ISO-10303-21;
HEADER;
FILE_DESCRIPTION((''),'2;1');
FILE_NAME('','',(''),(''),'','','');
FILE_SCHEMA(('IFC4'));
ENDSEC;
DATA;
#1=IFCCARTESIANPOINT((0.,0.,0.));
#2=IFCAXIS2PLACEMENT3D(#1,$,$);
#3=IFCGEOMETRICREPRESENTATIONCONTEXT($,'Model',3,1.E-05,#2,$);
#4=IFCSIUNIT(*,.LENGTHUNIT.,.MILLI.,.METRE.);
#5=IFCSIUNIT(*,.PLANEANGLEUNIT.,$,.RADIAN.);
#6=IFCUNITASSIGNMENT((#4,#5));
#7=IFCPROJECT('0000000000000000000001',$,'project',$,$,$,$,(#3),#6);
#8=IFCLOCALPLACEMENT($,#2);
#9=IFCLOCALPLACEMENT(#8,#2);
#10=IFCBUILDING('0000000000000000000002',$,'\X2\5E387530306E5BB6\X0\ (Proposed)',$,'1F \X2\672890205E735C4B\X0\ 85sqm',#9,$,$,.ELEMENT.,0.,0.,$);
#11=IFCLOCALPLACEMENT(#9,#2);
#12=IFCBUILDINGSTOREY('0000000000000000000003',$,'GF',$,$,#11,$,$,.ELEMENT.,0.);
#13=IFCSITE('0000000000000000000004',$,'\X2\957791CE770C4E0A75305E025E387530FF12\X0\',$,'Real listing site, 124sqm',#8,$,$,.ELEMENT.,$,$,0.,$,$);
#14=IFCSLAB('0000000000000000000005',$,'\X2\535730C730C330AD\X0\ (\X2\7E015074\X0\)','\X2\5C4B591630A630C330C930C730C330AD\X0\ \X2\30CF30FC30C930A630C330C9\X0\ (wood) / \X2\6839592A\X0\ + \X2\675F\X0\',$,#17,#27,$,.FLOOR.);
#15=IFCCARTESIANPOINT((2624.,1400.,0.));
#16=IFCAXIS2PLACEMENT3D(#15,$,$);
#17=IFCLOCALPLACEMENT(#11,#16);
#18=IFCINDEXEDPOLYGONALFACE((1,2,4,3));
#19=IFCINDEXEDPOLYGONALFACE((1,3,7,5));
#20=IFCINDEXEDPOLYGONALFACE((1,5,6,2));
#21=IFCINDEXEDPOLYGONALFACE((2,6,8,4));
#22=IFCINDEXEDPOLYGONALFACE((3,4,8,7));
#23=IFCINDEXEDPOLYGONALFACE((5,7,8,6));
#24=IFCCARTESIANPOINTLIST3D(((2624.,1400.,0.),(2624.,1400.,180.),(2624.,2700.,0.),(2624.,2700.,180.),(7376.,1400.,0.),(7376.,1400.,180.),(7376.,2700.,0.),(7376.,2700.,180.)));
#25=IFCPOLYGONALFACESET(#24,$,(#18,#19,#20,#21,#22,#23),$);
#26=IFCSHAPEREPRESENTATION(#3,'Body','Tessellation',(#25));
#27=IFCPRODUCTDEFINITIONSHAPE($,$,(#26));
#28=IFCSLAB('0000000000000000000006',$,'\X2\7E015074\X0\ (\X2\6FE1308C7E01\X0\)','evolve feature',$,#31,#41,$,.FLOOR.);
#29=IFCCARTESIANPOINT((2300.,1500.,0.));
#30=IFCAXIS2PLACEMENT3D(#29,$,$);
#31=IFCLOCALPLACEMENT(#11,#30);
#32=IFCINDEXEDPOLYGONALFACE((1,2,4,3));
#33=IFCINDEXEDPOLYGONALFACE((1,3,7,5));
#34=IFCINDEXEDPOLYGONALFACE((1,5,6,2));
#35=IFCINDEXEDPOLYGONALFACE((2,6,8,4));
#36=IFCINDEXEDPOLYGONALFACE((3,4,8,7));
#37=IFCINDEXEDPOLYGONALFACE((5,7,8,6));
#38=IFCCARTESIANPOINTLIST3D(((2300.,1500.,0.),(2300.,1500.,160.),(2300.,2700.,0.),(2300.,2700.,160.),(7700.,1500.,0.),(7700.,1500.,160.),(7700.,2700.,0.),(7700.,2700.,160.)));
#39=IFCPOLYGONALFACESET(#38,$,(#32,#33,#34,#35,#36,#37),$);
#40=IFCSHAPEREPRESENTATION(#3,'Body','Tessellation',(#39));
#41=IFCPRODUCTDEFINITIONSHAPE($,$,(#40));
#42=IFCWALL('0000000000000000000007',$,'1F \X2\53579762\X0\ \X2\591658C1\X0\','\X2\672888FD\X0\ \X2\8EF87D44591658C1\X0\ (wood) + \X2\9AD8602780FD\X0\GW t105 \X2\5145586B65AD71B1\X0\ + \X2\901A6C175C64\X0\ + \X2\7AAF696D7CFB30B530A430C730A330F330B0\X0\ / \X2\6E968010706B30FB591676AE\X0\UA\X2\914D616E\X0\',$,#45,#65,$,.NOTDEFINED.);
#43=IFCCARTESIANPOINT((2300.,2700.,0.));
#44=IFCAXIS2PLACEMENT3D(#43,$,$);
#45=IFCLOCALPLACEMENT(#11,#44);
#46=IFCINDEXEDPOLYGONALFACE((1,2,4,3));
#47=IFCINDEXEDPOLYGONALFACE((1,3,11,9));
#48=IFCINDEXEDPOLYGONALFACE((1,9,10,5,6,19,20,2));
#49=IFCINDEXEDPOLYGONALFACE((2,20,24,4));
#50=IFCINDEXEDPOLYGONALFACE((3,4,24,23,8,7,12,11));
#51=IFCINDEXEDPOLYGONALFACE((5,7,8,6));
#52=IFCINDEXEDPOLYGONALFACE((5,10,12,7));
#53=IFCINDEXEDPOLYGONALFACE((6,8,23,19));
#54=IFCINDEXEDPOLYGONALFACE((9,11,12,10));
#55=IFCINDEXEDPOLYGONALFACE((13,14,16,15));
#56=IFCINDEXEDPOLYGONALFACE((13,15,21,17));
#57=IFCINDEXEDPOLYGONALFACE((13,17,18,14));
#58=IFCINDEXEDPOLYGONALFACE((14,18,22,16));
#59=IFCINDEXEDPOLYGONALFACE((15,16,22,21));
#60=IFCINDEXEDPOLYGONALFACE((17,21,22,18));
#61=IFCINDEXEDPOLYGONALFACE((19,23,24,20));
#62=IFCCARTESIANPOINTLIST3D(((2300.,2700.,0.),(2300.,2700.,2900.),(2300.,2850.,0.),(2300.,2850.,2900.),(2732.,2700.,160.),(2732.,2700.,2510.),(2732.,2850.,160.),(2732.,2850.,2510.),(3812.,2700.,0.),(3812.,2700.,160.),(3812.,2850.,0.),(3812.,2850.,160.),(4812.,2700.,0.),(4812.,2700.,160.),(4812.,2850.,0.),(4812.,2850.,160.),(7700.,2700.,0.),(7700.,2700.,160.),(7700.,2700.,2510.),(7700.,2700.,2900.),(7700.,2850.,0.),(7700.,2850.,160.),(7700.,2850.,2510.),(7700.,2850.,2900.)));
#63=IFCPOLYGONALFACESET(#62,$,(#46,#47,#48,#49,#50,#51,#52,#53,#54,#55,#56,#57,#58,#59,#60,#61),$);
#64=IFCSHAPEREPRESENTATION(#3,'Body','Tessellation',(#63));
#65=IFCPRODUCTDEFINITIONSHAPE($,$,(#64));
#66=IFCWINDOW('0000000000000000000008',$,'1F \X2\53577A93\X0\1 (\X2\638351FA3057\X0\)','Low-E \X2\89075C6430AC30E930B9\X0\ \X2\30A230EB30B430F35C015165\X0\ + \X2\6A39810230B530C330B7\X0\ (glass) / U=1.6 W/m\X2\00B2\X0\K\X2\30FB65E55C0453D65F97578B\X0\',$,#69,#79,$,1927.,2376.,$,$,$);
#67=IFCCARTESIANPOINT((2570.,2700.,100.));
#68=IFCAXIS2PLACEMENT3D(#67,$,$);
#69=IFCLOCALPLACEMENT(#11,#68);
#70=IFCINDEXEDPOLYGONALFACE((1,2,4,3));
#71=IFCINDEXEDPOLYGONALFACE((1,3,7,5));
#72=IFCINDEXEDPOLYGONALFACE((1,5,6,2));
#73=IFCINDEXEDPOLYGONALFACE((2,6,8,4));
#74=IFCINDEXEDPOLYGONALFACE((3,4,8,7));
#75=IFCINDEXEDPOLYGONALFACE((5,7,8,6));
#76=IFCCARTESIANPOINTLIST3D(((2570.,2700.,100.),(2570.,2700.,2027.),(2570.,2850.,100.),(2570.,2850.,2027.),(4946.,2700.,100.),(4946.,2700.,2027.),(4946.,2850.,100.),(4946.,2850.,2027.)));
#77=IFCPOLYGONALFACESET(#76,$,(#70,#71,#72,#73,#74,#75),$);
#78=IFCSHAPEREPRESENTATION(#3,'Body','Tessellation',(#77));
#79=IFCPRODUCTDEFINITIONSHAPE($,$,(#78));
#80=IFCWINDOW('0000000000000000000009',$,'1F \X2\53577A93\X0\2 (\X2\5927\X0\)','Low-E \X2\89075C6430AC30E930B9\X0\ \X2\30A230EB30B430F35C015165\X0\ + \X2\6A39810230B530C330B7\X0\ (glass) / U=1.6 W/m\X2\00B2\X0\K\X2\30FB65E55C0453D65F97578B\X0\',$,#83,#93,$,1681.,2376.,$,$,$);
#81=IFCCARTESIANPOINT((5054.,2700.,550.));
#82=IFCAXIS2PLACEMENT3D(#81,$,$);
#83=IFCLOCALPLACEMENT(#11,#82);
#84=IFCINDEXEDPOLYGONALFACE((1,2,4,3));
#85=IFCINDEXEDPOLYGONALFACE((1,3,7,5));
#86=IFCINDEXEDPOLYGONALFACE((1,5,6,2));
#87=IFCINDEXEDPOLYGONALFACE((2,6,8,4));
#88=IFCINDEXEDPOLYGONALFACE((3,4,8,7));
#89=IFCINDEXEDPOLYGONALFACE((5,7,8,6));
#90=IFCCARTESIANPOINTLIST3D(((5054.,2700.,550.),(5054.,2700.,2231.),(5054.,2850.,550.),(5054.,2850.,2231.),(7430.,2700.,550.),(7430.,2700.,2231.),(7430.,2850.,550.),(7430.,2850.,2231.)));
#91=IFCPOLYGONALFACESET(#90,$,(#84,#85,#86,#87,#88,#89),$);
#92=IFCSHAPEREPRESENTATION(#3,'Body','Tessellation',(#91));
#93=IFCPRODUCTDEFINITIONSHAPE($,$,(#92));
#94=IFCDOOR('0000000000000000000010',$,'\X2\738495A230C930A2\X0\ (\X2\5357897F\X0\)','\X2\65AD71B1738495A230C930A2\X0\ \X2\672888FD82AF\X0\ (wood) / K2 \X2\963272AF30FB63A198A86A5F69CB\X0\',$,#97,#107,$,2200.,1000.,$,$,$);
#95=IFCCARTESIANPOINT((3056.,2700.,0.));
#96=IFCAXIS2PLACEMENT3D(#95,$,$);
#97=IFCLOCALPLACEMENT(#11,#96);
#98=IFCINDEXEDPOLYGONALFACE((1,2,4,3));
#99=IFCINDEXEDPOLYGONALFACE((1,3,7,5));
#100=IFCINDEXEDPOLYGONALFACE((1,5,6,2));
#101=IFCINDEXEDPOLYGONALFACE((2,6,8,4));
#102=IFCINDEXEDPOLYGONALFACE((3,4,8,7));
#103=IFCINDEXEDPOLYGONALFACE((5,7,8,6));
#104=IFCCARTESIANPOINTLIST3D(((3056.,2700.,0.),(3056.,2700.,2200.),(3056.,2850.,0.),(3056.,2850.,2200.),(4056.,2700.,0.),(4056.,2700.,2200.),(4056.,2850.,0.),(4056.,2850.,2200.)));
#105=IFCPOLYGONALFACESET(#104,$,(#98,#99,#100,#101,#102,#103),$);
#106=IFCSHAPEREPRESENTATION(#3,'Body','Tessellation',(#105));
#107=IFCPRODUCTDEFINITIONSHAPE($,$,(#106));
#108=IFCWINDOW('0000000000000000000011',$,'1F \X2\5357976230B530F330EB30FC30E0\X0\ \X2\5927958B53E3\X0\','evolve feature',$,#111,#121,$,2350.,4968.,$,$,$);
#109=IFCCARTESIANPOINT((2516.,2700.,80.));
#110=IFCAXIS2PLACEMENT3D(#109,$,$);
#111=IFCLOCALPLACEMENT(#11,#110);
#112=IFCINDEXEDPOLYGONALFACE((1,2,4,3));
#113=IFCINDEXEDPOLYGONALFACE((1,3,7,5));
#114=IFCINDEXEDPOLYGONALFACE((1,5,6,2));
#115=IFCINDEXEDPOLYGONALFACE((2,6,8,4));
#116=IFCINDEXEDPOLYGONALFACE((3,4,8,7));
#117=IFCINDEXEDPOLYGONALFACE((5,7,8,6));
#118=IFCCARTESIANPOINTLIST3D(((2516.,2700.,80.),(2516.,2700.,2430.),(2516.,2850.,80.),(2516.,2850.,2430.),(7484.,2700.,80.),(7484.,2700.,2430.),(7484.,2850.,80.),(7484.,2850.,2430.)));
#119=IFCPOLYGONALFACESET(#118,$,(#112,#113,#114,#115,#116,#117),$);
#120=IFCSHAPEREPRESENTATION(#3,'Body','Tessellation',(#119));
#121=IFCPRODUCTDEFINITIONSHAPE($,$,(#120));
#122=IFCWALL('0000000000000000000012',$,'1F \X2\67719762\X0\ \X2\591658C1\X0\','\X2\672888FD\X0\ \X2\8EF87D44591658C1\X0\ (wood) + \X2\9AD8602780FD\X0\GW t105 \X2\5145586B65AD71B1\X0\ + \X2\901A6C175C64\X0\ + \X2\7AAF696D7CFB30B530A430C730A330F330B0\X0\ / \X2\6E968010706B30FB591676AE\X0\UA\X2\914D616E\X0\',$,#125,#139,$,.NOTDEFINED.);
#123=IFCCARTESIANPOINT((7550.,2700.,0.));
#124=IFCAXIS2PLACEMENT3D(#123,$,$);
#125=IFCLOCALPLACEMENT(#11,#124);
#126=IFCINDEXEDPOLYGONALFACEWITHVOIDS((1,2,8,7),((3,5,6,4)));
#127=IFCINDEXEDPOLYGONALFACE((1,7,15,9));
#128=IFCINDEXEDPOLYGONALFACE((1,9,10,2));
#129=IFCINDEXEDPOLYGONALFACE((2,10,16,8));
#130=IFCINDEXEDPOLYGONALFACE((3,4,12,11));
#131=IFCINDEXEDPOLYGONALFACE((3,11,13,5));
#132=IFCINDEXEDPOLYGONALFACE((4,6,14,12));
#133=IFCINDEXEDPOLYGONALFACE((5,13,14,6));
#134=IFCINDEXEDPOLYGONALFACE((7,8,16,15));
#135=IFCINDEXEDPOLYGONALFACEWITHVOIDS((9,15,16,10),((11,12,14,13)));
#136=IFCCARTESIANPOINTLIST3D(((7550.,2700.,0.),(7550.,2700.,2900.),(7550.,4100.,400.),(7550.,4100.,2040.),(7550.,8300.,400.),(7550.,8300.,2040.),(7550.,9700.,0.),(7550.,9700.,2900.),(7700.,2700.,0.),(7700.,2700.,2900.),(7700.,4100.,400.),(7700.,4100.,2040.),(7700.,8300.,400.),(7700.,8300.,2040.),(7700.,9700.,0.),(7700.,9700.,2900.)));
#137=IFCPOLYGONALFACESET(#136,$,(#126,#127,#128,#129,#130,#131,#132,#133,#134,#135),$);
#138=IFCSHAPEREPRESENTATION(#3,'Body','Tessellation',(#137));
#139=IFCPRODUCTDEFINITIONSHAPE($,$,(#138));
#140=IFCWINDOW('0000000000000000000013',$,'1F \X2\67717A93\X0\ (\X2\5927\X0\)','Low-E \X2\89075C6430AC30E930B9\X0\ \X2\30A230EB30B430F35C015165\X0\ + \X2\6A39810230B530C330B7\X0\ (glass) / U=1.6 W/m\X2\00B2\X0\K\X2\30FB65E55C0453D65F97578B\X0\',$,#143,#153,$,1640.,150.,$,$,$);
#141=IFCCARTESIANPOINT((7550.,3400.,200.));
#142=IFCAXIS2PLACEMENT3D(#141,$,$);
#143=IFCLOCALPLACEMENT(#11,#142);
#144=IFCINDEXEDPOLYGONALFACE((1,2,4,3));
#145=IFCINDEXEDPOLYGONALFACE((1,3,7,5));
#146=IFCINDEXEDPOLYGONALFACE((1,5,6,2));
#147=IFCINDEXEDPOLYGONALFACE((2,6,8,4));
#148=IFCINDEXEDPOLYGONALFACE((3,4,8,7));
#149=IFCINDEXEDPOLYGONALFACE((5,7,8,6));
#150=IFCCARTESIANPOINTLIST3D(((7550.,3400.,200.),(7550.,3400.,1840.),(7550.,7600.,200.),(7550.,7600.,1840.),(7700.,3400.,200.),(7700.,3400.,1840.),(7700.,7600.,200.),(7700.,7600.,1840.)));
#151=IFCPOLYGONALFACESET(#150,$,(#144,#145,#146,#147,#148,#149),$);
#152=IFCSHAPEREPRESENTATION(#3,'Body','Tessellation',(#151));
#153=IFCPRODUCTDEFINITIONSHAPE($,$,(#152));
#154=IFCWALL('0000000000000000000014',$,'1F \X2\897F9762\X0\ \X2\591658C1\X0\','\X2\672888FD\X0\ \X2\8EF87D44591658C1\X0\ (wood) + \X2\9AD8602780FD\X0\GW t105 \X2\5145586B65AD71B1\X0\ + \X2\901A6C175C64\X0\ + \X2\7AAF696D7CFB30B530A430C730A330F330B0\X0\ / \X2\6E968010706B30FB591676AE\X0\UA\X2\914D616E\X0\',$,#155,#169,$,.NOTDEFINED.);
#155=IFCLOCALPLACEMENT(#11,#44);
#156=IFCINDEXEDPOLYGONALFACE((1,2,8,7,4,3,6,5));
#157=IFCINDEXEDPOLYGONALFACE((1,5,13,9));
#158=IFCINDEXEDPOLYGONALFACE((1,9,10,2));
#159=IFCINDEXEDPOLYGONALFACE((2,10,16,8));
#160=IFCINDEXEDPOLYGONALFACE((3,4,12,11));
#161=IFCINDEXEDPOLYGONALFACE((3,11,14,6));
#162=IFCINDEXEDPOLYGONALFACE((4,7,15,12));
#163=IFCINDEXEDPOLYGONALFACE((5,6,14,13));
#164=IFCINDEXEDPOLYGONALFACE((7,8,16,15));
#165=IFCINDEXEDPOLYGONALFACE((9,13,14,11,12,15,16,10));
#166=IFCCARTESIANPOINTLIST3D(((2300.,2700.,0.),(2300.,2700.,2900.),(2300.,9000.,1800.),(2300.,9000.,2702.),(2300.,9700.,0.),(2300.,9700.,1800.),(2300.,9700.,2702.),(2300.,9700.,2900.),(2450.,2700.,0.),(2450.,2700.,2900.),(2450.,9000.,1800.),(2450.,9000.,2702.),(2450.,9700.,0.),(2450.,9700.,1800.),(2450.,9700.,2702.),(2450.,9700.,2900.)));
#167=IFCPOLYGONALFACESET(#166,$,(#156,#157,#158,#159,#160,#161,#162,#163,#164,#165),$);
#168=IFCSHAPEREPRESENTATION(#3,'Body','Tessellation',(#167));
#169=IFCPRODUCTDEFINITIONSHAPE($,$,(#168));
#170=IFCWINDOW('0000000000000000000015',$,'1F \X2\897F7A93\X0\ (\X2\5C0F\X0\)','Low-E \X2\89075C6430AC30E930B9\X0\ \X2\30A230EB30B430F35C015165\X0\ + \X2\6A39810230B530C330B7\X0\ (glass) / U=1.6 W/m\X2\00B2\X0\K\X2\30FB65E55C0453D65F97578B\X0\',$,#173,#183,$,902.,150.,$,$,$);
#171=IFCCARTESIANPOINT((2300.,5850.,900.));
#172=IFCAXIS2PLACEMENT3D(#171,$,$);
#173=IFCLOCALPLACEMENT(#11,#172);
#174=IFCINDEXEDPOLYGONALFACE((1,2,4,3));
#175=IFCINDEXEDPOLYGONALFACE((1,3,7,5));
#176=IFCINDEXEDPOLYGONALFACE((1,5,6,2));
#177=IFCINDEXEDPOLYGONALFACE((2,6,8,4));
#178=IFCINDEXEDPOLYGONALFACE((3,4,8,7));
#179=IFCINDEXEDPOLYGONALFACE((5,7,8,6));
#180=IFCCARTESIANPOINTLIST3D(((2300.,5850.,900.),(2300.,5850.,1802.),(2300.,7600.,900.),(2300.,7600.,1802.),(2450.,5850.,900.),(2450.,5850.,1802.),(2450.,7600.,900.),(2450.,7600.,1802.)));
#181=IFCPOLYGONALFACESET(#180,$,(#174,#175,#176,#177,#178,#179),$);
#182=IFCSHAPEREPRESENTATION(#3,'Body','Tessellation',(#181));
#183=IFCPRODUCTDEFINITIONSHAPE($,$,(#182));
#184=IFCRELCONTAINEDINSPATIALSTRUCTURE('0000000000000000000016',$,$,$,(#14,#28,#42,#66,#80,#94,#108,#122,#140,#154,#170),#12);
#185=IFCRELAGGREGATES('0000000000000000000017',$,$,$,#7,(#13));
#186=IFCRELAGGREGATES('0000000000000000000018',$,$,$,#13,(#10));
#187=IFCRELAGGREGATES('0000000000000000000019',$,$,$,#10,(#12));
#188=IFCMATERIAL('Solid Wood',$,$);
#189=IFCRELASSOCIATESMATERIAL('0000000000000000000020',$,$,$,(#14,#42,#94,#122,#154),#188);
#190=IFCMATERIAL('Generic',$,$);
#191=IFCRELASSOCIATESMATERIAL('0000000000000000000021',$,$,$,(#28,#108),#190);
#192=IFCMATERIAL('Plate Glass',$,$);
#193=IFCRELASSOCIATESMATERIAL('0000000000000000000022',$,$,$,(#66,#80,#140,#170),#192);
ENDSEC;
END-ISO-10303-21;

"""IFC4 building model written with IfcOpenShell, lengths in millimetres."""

from ifc_helpers import new_model, si_unit, frame, frame_2d, origin, place, context, project, spatial, rectangle, extrude, material, element, fill, save


model = new_model("IFC4")

# Units and contexts
model_context = context("Model", 3, precision=1e-05, world=origin())
ifc_project = project(units=[si_unit("LENGTHUNIT", "METRE", prefix="MILLI"), si_unit("PLANEANGLEUNIT", "RADIAN")], contexts=[model_context])

# Site, building, storey
site_placement = place(None, origin())
site = spatial("IfcSite", under=ifc_project, at=site_placement, Name="長野県上田市常田２", ObjectType="Real listing site, 124sqm", CompositionType="ELEMENT", RefElevation=0.0)
building_placement = place(site_placement, origin())
building = spatial("IfcBuilding", under=site, at=building_placement, Name="常田の家 (Proposed)", ObjectType="1F 木造平屋 85sqm", CompositionType="ELEMENT", ElevationOfRefHeight=0.0, ElevationOfTerrain=0.0)
storey_placement = place(building_placement, origin())
storey = spatial("IfcBuildingStorey", under=building, at=storey_placement, Name="GF", CompositionType="ELEMENT", Elevation=0.0)

# Slabs
ifc_material_1 = material(Name="Solid Wood")
slab_1_placement = place(storey_placement, frame((2624.0, 1400.0, 0.0)))
element("IfcSlab", 1, at=slab_1_placement, inside=storey, material=ifc_material_1, Name="南デッキ (縁側)", Description="屋外ウッドデッキ ハードウッド (wood) / 根太 + 束", PredefinedType="FLOOR", context=model_context, shape_type="SweptSolid", body=[
    extrude(rectangle(XDim=4752.0, YDim=1300.0, at=frame_2d((2376.0, 650.0))), frame((2624.0, 1400.0, 0.0)), (0.0, 0.0, 1.0), 180.0),
])
ifc_material_2 = material(Name="Generic")
slab_2_placement = place(storey_placement, frame((2300.0, 1500.0, 0.0)))
element("IfcSlab", 2, at=slab_2_placement, inside=storey, material=ifc_material_2, Name="縁側 (濡れ縁)", Description="evolve feature", PredefinedType="FLOOR", context=model_context, shape_type="SweptSolid", body=[
    extrude(rectangle(XDim=5400.0, YDim=1200.0, at=frame_2d((2700.0, 600.0))), frame((2300.0, 1500.0, 0.0)), (0.0, 0.0, 1.0), 160.0),
])

# Wall, openings, windows, door
wall_1_placement = place(storey_placement, frame((2300.0, 2700.0, 0.0)))
wall_1 = element("IfcWall", 3, at=wall_1_placement, inside=storey, material=ifc_material_1, Name="1F 南面 外壁", Description="木製 軸組外壁 (wood) + 高性能GW t105 充填断熱 + 通気層 + 窯業系サイディング / 準耐火・外皮UA配慮", PredefinedType="NOTDEFINED", context=model_context, shape_type="SweptSolid", body=[
    extrude(rectangle(XDim=5400.0, YDim=150.0, at=frame_2d((2700.0, 75.0))), frame((2300.0, 2700.0, 0.0)), (0.0, 0.0, 1.0), 2900.0),
])
opening_1_placement = place(storey_placement, frame((2570.0, 2700.0, 100.0)))
opening_1 = element("IfcOpeningElement", 4, at=opening_1_placement, cuts=wall_1, PredefinedType="NOTDEFINED", context=model_context, shape_type="SweptSolid", body=[
    extrude(rectangle(XDim=2376.0, YDim=150.0, at=frame_2d((1188.0, 75.0))), frame((2570.0, 2700.0, 100.0)), (0.0, 0.0, 1.0), 1927.0),
])
opening_2_placement = place(storey_placement, frame((5054.0, 2700.0, 550.0)))
opening_2 = element("IfcOpeningElement", 5, at=opening_2_placement, cuts=wall_1, PredefinedType="NOTDEFINED", context=model_context, shape_type="SweptSolid", body=[
    extrude(rectangle(XDim=2376.0, YDim=150.0, at=frame_2d((1188.0, 75.0))), frame((5054.0, 2700.0, 550.0)), (0.0, 0.0, 1.0), 1681.0),
])
opening_3_placement = place(storey_placement, frame((3056.0, 2700.0, 0.0)))
opening_3 = element("IfcOpeningElement", 6, at=opening_3_placement, cuts=wall_1, PredefinedType="NOTDEFINED", context=model_context, shape_type="SweptSolid", body=[
    extrude(rectangle(XDim=1000.0, YDim=150.0, at=frame_2d((500.0, 75.0))), frame((3056.0, 2700.0, 0.0)), (0.0, 0.0, 1.0), 2200.0),
])
opening_4_placement = place(storey_placement, frame((2516.0, 2700.0, 80.0)))
opening_4 = element("IfcOpeningElement", 7, at=opening_4_placement, cuts=wall_1, PredefinedType="NOTDEFINED", context=model_context, shape_type="SweptSolid", body=[
    extrude(rectangle(XDim=4968.0, YDim=150.0, at=frame_2d((2484.0, 75.0))), frame((2516.0, 2700.0, 80.0)), (0.0, 0.0, 1.0), 2350.0),
])
ifc_material_3 = material(Name="Plate Glass")
window_1_placement = place(storey_placement, frame((2570.0, 2700.0, 100.0)))
window_1 = element("IfcWindow", 8, at=window_1_placement, inside=storey, material=ifc_material_3, Name="1F 南窓1 (掃出し)", Description="Low-E 複層ガラス アルゴン封入 + 樹脂サッシ (glass) / U=1.6 W/m²K・日射取得型", OverallHeight=1927.0, OverallWidth=2376.0, context=model_context, shape_type="SweptSolid", body=[
    extrude(rectangle(XDim=2376.0, YDim=150.0, at=frame_2d((1188.0, 75.0))), frame((2570.0, 2700.0, 100.0)), (0.0, 0.0, 1.0), 1927.0),
])
fill(opening_1, window_1)
window_2_placement = place(storey_placement, frame((5054.0, 2700.0, 550.0)))
window_2 = element("IfcWindow", 9, at=window_2_placement, inside=storey, material=ifc_material_3, Name="1F 南窓2 (大)", Description="Low-E 複層ガラス アルゴン封入 + 樹脂サッシ (glass) / U=1.6 W/m²K・日射取得型", OverallHeight=1681.0, OverallWidth=2376.0, context=model_context, shape_type="SweptSolid", body=[
    extrude(rectangle(XDim=2376.0, YDim=150.0, at=frame_2d((1188.0, 75.0))), frame((5054.0, 2700.0, 550.0)), (0.0, 0.0, 1.0), 1681.0),
])
fill(opening_2, window_2)
door_placement = place(storey_placement, frame((3056.0, 2700.0, 0.0)))
door = element("IfcDoor", 10, at=door_placement, inside=storey, material=ifc_material_1, Name="玄関ドア (南西)", Description="断熱玄関ドア 木製芯 (wood) / K2 防犯・採風機構", OverallHeight=2200.0, OverallWidth=1000.0, context=model_context, shape_type="SweptSolid", body=[
    extrude(rectangle(XDim=1000.0, YDim=150.0, at=frame_2d((500.0, 75.0))), frame((3056.0, 2700.0, 0.0)), (0.0, 0.0, 1.0), 2200.0),
])
fill(opening_3, door)
window_3_placement = place(storey_placement, frame((2516.0, 2700.0, 80.0)))
window_3 = element("IfcWindow", 11, at=window_3_placement, inside=storey, material=ifc_material_2, Name="1F 南面サンルーム 大開口", Description="evolve feature", OverallHeight=2350.0, OverallWidth=4968.0, context=model_context, shape_type="SweptSolid", body=[
    extrude(rectangle(XDim=4968.0, YDim=150.0, at=frame_2d((2484.0, 75.0))), frame((2516.0, 2700.0, 80.0)), (0.0, 0.0, 1.0), 2350.0),
])
fill(opening_4, window_3)

# Walls, openings, windows
wall_2_placement = place(storey_placement, frame((7550.0, 2700.0, 0.0)))
wall_2 = element("IfcWall", 12, at=wall_2_placement, inside=storey, material=ifc_material_1, Name="1F 東面 外壁", Description="木製 軸組外壁 (wood) + 高性能GW t105 充填断熱 + 通気層 + 窯業系サイディング / 準耐火・外皮UA配慮", PredefinedType="NOTDEFINED", context=model_context, shape_type="SweptSolid", body=[
    extrude(rectangle(XDim=150.0, YDim=7000.0, at=frame_2d((75.0, 3500.0))), frame((7550.0, 2700.0, 0.0)), (0.0, 0.0, 1.0), 2900.0),
])
opening_5_placement = place(storey_placement, frame((7550.0, 3400.0, 200.0)))
opening_5 = element("IfcOpeningElement", 13, at=opening_5_placement, cuts=wall_2, PredefinedType="NOTDEFINED", context=model_context, shape_type="SweptSolid", body=[
    extrude(rectangle(XDim=150.0, YDim=4200.0, at=frame_2d((75.0, 2100.0))), frame((7550.0, 3400.0, 200.0)), (0.0, 0.0, 1.0), 1640.0),
])
window_4_placement = place(storey_placement, frame((7550.0, 3400.0, 200.0)))
window_4 = element("IfcWindow", 14, at=window_4_placement, inside=storey, material=ifc_material_3, Name="1F 東窓 (大)", Description="Low-E 複層ガラス アルゴン封入 + 樹脂サッシ (glass) / U=1.6 W/m²K・日射取得型", OverallHeight=1640.0, OverallWidth=150.0, context=model_context, shape_type="SweptSolid", body=[
    extrude(rectangle(XDim=150.0, YDim=4200.0, at=frame_2d((75.0, 2100.0))), frame((7550.0, 3400.0, 200.0)), (0.0, 0.0, 1.0), 1640.0),
])
fill(opening_5, window_4)
wall_3_placement = place(storey_placement, frame((2300.0, 2700.0, 0.0)))
wall_3 = element("IfcWall", 15, at=wall_3_placement, inside=storey, material=ifc_material_1, Name="1F 西面 外壁", Description="木製 軸組外壁 (wood) + 高性能GW t105 充填断熱 + 通気層 + 窯業系サイディング / 準耐火・外皮UA配慮", PredefinedType="NOTDEFINED", context=model_context, shape_type="SweptSolid", body=[
    extrude(rectangle(XDim=150.0, YDim=7000.0, at=frame_2d((75.0, 3500.0))), frame((2300.0, 2700.0, 0.0)), (0.0, 0.0, 1.0), 2900.0),
])
opening_6_placement = place(storey_placement, frame((2300.0, 5850.0, 900.0)))
opening_6 = element("IfcOpeningElement", 16, at=opening_6_placement, cuts=wall_3, PredefinedType="NOTDEFINED", context=model_context, shape_type="SweptSolid", body=[
    extrude(rectangle(XDim=150.0, YDim=1750.0, at=frame_2d((75.0, 875.0))), frame((2300.0, 5850.0, 900.0)), (0.0, 0.0, 1.0), 902.0),
])
window_5_placement = place(storey_placement, frame((2300.0, 5850.0, 900.0)))
window_5 = element("IfcWindow", 17, at=window_5_placement, inside=storey, material=ifc_material_3, Name="1F 西窓 (小)", Description="Low-E 複層ガラス アルゴン封入 + 樹脂サッシ (glass) / U=1.6 W/m²K・日射取得型", OverallHeight=902.0, OverallWidth=150.0, context=model_context, shape_type="SweptSolid", body=[
    extrude(rectangle(XDim=150.0, YDim=1750.0, at=frame_2d((75.0, 875.0))), frame((2300.0, 5850.0, 900.0)), (0.0, 0.0, 1.0), 902.0),
])
fill(opening_6, window_5)

save(model, "model.ifc")
